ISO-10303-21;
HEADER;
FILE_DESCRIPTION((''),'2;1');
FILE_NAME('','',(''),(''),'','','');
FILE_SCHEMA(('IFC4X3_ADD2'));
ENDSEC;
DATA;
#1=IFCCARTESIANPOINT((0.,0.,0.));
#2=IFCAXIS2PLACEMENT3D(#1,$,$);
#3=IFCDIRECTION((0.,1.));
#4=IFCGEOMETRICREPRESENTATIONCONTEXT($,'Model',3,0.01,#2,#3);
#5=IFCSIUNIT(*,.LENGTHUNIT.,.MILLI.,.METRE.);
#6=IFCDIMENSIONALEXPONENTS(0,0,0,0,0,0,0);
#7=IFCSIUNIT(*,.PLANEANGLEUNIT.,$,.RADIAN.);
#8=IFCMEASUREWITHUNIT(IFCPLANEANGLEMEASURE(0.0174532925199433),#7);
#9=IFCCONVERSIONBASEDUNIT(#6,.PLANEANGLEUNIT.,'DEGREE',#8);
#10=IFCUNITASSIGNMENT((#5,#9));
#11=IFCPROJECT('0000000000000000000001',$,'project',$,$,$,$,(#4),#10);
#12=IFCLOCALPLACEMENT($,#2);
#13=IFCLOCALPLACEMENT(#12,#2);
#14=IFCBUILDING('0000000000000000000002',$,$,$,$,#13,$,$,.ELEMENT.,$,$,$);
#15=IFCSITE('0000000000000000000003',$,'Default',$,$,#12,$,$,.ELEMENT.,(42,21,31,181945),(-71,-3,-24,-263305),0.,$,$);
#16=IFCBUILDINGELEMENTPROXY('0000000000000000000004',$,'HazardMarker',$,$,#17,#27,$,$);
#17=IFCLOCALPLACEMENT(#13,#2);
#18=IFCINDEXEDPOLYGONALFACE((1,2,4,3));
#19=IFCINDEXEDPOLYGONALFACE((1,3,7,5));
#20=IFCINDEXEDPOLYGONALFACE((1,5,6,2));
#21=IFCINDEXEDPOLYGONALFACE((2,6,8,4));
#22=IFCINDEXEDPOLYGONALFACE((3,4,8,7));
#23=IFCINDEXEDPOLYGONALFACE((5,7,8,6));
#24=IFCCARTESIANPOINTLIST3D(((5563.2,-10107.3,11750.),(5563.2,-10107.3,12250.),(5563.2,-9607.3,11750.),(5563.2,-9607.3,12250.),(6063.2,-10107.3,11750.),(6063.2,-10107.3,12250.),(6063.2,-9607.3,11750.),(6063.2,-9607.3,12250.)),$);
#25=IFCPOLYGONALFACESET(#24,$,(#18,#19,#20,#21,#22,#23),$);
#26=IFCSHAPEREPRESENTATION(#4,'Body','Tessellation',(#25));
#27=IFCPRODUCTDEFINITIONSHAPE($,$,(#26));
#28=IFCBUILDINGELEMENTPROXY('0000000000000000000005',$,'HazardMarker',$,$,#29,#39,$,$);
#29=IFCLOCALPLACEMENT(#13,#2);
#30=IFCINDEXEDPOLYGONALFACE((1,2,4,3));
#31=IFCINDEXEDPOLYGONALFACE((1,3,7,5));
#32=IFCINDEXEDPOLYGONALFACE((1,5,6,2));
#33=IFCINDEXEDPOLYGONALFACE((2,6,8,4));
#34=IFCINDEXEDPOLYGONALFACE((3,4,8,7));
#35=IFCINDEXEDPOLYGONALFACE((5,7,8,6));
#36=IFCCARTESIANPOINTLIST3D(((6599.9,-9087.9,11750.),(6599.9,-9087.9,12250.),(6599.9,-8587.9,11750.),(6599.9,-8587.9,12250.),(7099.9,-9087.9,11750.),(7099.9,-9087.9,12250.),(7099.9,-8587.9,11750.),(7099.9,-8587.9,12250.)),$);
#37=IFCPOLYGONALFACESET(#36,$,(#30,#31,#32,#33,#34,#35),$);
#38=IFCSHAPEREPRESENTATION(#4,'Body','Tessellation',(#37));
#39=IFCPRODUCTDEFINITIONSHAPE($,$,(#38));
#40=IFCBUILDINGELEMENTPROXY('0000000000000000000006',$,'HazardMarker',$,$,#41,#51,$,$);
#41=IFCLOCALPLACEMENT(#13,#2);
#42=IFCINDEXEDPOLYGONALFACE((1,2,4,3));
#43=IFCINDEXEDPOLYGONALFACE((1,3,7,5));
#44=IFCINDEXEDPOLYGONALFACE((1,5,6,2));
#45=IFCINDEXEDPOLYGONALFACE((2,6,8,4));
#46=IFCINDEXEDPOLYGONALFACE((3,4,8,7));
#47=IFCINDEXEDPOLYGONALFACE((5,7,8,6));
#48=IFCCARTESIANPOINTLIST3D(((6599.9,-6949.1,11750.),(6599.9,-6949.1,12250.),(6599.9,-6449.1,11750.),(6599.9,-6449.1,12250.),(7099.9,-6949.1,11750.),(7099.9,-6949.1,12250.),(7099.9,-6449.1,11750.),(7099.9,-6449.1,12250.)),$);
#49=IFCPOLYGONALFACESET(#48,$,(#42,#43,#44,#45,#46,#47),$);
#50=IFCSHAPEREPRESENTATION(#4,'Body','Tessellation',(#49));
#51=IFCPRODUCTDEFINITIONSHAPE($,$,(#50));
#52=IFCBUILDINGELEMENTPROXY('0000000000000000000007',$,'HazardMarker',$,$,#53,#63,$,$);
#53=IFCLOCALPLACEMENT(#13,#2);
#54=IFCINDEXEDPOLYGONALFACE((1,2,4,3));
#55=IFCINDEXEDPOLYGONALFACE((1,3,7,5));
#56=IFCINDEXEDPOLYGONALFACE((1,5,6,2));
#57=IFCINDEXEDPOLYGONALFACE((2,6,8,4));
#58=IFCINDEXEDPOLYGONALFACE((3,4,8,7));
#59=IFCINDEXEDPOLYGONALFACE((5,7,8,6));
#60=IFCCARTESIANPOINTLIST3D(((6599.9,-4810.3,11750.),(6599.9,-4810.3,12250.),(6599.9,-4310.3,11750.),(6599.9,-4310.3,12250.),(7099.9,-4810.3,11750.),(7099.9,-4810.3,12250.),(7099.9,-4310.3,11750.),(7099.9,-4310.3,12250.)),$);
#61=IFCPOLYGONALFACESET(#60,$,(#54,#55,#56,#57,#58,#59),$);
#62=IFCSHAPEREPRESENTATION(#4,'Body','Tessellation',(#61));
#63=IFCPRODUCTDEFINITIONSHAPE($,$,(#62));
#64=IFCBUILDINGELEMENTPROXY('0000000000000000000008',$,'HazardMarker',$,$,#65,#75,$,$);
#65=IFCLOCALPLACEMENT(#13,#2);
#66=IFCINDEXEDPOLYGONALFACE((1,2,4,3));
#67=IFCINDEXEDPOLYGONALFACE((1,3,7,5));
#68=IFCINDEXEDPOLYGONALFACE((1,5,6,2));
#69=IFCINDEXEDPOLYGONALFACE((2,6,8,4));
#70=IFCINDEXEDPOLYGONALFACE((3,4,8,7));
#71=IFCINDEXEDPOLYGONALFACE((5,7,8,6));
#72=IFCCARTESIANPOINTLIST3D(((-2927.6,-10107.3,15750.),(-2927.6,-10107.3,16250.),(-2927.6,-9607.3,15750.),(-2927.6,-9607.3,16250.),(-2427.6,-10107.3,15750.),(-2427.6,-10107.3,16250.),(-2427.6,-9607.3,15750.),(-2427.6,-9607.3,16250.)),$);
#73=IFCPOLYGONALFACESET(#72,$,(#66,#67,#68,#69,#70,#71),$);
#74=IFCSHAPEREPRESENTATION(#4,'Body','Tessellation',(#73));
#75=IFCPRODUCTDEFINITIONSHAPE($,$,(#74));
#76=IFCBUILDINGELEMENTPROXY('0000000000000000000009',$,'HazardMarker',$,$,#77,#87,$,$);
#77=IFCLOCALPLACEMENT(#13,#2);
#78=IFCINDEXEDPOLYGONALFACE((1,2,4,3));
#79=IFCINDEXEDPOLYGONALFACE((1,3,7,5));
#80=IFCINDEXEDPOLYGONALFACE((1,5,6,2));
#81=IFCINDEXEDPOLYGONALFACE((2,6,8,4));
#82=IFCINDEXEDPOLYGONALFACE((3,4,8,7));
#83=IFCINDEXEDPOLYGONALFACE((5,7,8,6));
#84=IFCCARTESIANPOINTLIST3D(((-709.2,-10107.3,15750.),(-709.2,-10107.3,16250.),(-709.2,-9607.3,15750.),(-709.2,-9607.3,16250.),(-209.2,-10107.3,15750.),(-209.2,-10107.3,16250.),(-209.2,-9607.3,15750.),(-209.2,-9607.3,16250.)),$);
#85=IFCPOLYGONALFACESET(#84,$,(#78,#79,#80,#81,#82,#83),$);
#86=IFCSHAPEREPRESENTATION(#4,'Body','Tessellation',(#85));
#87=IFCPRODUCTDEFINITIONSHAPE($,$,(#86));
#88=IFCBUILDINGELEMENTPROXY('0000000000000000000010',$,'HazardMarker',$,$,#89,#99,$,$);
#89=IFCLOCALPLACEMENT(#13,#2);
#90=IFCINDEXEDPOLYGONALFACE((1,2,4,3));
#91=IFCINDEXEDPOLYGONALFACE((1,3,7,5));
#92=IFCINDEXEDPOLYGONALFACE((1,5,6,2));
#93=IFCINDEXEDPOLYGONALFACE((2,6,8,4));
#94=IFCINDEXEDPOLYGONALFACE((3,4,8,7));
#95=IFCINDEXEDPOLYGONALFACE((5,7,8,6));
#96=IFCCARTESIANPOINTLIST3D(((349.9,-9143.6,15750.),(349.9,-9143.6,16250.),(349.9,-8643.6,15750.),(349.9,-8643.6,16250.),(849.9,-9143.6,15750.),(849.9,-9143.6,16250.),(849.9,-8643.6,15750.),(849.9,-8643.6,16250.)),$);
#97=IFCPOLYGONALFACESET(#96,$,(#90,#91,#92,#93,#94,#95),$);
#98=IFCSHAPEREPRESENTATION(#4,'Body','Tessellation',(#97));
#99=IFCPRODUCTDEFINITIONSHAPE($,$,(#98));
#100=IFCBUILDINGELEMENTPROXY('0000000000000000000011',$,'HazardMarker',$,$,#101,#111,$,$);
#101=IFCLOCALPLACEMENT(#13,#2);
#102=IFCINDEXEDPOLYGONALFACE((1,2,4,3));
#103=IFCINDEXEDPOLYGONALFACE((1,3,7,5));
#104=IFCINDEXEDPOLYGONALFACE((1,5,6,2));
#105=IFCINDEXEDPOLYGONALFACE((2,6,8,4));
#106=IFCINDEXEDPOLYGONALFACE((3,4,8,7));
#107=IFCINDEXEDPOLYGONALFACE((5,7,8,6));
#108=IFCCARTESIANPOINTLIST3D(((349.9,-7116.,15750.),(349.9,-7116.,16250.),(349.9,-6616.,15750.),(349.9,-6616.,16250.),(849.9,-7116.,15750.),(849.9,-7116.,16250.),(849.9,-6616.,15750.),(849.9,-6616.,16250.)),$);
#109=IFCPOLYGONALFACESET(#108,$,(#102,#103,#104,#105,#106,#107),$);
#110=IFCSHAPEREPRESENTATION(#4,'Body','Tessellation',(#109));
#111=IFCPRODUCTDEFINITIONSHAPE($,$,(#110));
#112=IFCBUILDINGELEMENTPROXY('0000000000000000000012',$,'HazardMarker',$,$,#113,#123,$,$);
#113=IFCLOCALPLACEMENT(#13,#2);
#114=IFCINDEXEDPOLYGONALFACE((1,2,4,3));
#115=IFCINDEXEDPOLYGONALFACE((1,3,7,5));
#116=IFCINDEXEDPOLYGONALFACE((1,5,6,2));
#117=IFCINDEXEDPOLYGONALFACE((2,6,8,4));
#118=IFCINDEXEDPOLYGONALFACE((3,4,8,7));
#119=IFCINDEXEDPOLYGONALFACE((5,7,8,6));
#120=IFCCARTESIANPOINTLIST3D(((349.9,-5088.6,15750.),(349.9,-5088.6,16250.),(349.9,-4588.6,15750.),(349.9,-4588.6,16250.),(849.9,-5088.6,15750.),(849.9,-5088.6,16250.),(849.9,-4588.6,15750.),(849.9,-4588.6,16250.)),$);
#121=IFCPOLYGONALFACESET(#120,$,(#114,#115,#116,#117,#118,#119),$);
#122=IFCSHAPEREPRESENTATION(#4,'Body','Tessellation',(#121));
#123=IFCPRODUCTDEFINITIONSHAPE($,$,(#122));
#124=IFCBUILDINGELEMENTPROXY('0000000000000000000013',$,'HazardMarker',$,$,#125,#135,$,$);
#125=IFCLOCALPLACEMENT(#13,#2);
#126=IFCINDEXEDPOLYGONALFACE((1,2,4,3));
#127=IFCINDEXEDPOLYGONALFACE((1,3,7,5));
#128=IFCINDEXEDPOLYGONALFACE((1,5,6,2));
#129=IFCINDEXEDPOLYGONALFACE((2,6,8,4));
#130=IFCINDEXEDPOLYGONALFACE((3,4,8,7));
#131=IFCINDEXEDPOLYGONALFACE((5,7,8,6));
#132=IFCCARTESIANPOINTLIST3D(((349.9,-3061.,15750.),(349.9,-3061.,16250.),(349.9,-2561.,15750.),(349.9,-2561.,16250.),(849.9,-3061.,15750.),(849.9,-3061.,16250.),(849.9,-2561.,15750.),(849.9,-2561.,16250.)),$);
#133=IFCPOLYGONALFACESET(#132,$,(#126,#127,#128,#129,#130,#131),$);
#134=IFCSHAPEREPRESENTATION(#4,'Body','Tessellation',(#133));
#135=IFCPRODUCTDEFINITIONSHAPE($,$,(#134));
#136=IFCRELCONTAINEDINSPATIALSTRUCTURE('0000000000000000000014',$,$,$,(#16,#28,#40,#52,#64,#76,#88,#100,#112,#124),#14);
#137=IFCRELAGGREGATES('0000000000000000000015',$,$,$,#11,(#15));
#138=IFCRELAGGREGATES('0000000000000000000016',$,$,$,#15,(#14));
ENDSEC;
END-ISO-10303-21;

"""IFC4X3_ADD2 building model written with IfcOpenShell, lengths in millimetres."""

from ifc_helpers import new_model, entity, si_unit, converted_unit, direction, frame, origin, place, context, project, spatial, rectangle, extrude, element, save


model = new_model("IFC4X3_ADD2")

# Units and contexts
model_context = context("Model", 3, precision=0.01, world=origin(), true_north=direction((0.0, 1.0)))
ifc_project = project(units=[si_unit("LENGTHUNIT", "METRE", prefix="MILLI"), converted_unit("PLANEANGLEUNIT", "DEGREE", entity("IfcPlaneAngleMeasure", 0.0174532925199433), si_unit("PLANEANGLEUNIT", "RADIAN"), dimensions=[0, 0, 0, 0, 0, 0, 0])], contexts=[model_context])

# Site, building
site_placement = place(None, origin())
site = spatial("IfcSite", under=ifc_project, at=site_placement, Name="Default", CompositionType="ELEMENT", RefLatitude=(42, 21, 31, 181945), RefLongitude=(-71, -3, -24, -263305), RefElevation=0.0)
building_placement = place(site_placement, origin())
building = spatial("IfcBuilding", under=site, at=building_placement, CompositionType="ELEMENT")

# Building element proxies
for number, where, name in (
    (1, (5813.2, -9857.3, 12000.0), "HazardMarker"),
    (2, (6849.9, -8837.9, 12000.0), "HazardMarker"),
    (3, (6849.9, -6699.1, 12000.0), "HazardMarker"),
    (4, (6849.9, -4560.3, 12000.0), "HazardMarker"),
    (5, (-2677.6, -9857.3, 16000.0), "HazardMarker"),
    (6, (-459.2, -9857.3, 16000.0), "HazardMarker"),
    (7, (599.9, -8893.5, 16000.0), "HazardMarker"),
    (8, (599.9, -6866.1, 16000.0), "HazardMarker"),
    (9, (599.9, -4838.6, 16000.0), "HazardMarker"),
    (10, (599.9, -2811.1, 16000.0), "HazardMarker"),
):
    element("IfcBuildingElementProxy", number, at=place(None, frame(where)), inside=building, Name=name, context=model_context, shape_type="SweptSolid", body=[
        extrude(rectangle(XDim=500.0, YDim=500.0), frame((0.0, 0.0, -250.0)), (0.0, 0.0, 1.0), 500.0),
    ])

save(model, "model.ifc")
